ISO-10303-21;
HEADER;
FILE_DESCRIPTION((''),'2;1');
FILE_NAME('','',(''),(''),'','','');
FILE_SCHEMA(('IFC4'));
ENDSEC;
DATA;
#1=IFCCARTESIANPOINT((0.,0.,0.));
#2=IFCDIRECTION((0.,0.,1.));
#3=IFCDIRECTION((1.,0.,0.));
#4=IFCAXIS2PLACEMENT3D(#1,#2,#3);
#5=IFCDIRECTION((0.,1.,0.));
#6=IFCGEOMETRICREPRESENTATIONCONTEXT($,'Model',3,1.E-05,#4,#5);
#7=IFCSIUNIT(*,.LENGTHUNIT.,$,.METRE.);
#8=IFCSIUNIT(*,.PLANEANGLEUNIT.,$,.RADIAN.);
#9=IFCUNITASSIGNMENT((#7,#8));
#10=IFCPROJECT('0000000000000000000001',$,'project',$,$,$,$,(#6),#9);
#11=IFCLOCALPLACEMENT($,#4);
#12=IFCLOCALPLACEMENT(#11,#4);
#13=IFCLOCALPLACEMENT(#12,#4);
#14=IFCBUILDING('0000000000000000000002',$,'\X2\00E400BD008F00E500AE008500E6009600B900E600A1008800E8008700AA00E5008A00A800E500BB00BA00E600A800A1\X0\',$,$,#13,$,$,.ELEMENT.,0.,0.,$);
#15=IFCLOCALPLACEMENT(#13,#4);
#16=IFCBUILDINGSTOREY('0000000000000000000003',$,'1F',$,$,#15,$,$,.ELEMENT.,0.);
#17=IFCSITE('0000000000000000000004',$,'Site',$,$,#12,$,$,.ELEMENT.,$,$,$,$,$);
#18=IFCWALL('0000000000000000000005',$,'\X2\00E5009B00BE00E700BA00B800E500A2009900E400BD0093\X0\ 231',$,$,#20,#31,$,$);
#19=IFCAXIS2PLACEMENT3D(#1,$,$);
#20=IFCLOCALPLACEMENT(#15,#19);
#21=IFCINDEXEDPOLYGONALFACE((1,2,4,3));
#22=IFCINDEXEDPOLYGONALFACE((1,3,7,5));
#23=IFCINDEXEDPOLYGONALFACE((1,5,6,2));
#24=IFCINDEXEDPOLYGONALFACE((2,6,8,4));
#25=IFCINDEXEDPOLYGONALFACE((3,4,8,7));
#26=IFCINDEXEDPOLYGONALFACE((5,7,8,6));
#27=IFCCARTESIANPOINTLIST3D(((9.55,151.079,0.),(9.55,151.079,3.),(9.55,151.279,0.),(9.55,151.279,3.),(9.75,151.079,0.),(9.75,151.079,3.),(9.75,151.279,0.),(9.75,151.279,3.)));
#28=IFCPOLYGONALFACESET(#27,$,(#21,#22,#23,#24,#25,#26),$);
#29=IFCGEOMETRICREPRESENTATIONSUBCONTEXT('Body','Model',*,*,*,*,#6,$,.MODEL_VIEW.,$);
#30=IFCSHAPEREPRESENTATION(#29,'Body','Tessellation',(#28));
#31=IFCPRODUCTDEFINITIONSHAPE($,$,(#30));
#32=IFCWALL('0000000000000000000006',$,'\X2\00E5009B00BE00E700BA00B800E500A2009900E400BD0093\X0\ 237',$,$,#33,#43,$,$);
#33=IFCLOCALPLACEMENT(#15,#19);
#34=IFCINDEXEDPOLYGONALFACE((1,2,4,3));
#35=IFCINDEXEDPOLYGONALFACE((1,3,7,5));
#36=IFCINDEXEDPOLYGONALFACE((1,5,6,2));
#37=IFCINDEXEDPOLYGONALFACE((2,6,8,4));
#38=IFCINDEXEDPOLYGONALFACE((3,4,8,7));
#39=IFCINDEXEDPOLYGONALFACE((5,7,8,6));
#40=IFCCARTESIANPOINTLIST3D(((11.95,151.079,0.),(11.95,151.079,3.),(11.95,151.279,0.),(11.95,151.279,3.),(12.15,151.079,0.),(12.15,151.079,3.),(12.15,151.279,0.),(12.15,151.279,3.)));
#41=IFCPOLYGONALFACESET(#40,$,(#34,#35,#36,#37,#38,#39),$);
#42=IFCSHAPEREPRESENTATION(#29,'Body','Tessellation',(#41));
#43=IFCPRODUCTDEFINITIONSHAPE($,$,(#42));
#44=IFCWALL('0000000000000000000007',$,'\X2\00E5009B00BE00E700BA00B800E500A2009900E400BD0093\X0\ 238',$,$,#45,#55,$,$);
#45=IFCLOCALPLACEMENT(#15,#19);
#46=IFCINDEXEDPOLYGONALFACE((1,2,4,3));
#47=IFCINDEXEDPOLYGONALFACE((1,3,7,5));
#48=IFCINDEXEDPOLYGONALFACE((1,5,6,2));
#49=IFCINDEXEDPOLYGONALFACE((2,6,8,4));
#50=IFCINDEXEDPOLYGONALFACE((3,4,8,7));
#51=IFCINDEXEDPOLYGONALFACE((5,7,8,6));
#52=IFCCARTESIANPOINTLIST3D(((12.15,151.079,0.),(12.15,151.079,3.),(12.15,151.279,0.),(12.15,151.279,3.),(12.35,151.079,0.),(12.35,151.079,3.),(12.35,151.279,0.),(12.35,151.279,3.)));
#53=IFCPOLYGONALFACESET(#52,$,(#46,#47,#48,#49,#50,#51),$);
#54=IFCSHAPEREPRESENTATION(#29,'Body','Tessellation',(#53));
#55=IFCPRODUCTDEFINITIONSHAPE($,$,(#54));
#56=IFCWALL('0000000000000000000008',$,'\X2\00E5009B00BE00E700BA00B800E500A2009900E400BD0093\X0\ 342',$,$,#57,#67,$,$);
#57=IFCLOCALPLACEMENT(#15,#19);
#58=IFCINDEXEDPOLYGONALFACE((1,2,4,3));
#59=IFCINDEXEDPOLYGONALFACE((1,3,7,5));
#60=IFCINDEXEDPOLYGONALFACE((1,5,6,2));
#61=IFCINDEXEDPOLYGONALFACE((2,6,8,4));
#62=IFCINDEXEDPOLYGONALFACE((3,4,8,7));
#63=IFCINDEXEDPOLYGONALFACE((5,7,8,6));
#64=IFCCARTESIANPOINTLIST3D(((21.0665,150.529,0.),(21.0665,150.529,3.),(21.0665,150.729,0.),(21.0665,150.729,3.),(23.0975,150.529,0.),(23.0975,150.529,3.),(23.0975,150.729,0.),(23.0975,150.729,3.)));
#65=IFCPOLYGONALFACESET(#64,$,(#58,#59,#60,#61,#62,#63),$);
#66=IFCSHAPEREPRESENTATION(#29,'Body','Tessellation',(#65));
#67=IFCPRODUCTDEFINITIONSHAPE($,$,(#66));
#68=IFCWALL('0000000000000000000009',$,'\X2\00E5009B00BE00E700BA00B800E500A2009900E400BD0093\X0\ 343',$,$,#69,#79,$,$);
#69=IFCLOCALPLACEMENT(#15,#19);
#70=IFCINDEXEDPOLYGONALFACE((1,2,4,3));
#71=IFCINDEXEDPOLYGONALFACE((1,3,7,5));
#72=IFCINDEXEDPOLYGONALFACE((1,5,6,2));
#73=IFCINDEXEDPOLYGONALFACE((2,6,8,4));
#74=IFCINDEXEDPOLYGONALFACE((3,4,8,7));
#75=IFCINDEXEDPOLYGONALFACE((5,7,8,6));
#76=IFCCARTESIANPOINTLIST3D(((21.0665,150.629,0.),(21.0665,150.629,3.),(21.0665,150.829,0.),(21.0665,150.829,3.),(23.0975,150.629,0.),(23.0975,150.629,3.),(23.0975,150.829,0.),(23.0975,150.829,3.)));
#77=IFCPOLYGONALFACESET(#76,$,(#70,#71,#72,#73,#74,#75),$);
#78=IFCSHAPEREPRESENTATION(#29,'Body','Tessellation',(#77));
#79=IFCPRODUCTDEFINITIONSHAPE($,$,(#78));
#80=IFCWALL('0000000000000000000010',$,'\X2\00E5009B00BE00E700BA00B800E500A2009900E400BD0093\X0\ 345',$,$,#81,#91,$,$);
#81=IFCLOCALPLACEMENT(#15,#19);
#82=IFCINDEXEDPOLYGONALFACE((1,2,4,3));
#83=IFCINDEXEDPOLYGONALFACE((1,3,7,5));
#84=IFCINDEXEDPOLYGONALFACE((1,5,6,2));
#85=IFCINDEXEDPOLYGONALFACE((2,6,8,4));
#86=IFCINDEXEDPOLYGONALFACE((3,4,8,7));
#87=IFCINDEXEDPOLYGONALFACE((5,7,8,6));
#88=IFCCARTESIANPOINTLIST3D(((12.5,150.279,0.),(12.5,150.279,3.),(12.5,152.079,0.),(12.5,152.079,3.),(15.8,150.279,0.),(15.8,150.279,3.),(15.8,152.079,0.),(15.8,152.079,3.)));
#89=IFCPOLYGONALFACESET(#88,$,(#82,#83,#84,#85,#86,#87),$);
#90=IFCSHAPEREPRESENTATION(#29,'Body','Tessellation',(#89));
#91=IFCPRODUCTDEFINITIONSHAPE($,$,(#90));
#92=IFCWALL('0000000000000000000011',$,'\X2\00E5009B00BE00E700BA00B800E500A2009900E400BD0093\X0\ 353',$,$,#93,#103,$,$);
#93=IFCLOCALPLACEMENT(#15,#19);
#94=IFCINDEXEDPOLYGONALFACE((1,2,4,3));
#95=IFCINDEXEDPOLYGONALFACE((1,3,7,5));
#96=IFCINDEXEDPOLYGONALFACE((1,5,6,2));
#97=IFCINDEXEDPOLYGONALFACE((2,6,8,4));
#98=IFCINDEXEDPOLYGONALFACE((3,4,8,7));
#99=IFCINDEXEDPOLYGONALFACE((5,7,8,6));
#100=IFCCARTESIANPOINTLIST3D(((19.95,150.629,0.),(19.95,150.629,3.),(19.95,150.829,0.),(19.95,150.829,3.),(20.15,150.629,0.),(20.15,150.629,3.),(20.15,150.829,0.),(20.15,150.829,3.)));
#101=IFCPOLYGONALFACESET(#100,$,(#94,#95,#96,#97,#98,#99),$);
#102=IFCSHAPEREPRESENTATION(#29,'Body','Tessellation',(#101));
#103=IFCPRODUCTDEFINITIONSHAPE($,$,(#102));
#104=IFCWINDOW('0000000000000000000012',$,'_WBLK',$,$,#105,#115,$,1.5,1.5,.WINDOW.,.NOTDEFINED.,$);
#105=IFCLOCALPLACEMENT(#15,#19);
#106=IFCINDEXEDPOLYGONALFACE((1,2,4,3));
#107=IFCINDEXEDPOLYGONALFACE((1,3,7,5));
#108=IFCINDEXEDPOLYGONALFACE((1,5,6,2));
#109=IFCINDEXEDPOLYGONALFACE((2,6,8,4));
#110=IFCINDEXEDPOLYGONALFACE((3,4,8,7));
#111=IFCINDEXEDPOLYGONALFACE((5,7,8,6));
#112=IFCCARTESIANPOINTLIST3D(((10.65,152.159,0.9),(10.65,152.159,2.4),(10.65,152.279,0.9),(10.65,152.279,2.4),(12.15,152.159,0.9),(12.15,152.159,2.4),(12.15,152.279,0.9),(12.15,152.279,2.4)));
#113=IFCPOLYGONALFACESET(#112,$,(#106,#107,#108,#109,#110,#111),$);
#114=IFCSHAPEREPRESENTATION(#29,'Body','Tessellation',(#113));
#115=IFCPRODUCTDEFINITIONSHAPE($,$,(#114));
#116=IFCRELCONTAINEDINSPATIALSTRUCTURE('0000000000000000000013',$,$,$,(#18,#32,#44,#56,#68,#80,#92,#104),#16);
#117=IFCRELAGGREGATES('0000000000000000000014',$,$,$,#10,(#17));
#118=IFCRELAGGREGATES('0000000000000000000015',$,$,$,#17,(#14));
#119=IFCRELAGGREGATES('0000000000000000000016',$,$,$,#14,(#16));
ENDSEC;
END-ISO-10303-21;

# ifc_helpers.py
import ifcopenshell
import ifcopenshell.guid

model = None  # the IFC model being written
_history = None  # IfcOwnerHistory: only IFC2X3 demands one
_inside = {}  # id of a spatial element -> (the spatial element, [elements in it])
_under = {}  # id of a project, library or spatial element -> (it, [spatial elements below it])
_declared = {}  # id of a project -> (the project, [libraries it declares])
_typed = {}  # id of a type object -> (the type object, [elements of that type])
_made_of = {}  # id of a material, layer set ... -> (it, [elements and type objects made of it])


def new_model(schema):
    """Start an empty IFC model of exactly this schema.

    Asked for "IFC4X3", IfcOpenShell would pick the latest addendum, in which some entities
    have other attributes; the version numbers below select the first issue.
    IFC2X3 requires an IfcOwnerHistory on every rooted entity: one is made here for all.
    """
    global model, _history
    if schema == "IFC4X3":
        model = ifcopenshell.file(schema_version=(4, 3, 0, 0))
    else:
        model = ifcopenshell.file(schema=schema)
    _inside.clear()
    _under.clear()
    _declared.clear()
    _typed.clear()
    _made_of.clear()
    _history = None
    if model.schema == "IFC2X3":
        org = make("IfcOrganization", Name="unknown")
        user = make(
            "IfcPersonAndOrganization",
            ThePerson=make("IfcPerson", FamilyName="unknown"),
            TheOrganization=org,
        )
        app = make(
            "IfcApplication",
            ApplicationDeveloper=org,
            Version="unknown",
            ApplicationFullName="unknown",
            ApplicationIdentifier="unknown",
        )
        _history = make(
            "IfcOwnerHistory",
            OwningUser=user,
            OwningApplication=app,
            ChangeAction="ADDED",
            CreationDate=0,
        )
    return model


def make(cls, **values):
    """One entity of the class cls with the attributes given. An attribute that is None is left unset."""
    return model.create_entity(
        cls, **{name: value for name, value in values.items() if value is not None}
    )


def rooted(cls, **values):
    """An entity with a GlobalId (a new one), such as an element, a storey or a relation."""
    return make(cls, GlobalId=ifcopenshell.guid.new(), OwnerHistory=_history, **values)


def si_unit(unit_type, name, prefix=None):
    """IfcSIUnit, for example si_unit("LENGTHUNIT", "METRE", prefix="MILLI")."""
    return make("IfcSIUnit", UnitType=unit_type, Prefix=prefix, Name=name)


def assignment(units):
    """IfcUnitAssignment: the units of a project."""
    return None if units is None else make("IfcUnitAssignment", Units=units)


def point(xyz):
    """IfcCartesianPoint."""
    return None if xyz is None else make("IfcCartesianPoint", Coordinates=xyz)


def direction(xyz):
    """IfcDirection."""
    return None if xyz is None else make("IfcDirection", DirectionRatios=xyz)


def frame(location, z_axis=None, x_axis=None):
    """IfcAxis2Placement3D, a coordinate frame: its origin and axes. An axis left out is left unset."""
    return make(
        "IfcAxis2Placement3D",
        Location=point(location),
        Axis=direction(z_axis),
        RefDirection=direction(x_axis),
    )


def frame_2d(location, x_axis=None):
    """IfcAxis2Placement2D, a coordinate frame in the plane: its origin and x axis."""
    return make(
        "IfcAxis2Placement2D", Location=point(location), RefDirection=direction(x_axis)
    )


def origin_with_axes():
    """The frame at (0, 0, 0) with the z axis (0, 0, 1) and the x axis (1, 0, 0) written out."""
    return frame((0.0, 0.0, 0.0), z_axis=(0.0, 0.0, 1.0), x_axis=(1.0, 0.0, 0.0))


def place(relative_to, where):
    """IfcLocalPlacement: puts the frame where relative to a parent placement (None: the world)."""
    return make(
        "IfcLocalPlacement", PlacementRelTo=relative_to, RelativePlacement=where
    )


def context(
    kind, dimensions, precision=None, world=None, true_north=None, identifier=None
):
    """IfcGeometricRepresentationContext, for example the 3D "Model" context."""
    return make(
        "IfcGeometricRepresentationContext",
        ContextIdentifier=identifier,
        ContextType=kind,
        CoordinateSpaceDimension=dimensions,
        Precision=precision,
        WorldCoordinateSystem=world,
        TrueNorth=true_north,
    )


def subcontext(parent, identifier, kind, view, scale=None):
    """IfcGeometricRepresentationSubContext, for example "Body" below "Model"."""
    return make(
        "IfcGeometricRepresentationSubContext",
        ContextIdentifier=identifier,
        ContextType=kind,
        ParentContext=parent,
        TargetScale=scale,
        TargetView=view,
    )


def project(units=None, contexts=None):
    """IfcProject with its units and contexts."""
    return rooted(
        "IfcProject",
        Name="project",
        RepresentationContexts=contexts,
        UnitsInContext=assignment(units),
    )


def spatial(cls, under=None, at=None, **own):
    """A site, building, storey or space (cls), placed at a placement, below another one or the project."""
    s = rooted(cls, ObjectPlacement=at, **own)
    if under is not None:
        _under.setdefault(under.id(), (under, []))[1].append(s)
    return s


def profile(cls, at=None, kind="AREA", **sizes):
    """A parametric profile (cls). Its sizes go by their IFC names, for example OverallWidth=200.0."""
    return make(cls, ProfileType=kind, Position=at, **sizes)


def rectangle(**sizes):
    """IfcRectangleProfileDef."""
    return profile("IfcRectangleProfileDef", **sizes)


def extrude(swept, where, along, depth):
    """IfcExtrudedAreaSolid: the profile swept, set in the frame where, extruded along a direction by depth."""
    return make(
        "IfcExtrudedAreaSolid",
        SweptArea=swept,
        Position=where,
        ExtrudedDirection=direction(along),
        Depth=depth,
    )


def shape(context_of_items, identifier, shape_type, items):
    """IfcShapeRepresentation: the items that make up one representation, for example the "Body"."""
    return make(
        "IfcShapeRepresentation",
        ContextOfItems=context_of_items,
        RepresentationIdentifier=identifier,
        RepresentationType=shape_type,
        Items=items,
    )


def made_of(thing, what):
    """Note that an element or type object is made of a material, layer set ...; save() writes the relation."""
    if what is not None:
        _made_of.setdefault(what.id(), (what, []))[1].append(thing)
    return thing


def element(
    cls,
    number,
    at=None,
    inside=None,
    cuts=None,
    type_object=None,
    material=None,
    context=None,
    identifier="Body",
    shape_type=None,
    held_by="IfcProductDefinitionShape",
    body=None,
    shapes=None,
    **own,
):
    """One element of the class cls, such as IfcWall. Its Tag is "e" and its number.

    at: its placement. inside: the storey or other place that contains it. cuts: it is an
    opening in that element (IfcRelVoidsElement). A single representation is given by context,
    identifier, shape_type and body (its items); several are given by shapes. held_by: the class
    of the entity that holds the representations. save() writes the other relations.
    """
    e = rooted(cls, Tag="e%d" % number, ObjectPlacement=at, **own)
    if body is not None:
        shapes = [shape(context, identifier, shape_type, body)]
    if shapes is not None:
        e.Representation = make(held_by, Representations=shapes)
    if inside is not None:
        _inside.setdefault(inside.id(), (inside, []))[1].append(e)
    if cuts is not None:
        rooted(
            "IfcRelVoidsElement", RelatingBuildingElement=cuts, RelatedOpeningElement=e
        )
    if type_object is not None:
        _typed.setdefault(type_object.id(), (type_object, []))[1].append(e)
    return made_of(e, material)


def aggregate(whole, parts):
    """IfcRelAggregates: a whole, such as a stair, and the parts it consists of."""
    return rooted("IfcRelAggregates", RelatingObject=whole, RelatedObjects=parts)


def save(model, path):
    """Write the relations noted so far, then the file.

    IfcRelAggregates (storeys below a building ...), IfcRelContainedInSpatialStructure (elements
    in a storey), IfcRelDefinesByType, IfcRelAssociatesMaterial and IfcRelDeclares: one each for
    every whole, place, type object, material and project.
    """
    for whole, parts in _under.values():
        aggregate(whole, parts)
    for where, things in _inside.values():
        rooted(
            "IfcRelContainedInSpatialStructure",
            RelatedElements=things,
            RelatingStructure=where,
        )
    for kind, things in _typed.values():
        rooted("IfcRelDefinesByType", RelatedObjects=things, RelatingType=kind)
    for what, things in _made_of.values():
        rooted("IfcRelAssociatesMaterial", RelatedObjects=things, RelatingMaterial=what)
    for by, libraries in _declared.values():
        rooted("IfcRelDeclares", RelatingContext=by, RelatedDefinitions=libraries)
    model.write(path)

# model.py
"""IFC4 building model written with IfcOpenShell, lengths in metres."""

from ifc_helpers import new_model, si_unit, direction, frame, frame_2d, origin_with_axes, place, context, subcontext, project, spatial, rectangle, extrude, element, save


model = new_model("IFC4")

# Units and contexts
model_context = context("Model", 3, precision=1e-05, world=origin_with_axes(), true_north=direction((0.0, 1.0, 0.0)))
body_context = subcontext(model_context, "Body", "Model", "MODEL_VIEW")
ifc_project = project(units=[si_unit("LENGTHUNIT", "METRE"), si_unit("PLANEANGLEUNIT", "RADIAN")], contexts=[model_context])

# Site, building, storey
placement = place(None, origin_with_axes())
site_placement = place(placement, origin_with_axes())
site = spatial("IfcSite", under=ifc_project, at=site_placement, Name="Site", CompositionType="ELEMENT")
building_placement = place(site_placement, origin_with_axes())
building = spatial("IfcBuilding", under=site, at=building_placement, Name="ä½\u008få®\u0085æ\u0096¹æ¡\u0088è\u0087ªå\u008a¨å»ºæ¨¡", CompositionType="ELEMENT", ElevationOfRefHeight=0.0, ElevationOfTerrain=0.0)
storey_placement = place(building_placement, origin_with_axes())
storey = spatial("IfcBuildingStorey", under=building, at=storey_placement, Name="1F", CompositionType="ELEMENT", Elevation=0.0)

# Walls
for number, where, z_axis, x_axis, name in (
    (1, (9.65, 151.179, 0.0), (0.0, 0.0, 1.0), (1.0, 0.0, 0.0), "å\u009b¾çº¸å¢\u0099ä½\u0093 231"),
    (2, (12.05, 151.179, 0.0), (0.0, 0.0, 1.0), (1.0, 0.0, 0.0), "å\u009b¾çº¸å¢\u0099ä½\u0093 237"),
    (3, (12.25, 151.179, 0.0), (0.0, 0.0, 1.0), (-1.0, 0.0, 0.0), "å\u009b¾çº¸å¢\u0099ä½\u0093 238"),
):
    element("IfcWall", number, at=place(storey_placement, frame(where, z_axis=z_axis, x_axis=x_axis)), inside=storey, Name=name, context=body_context, shape_type="SweptSolid", body=[
        extrude(rectangle(XDim=0.2, YDim=0.2, at=frame_2d((0.0, 0.0), x_axis=(1.0, 0.0, 0.0))), frame((0.0, 0.0, 0.0), z_axis=(0.0, 0.0, 1.0)), (0.0, 0.0, 1.0), 3.0),
    ])
for number, where, z_axis, x_axis, name in (
    (4, (22.082, 150.629, 0.0), (0.0, 0.0, 1.0), (-1.0, 0.0, 0.0), "å\u009b¾çº¸å¢\u0099ä½\u0093 342"),
    (5, (22.082, 150.729, 0.0), (0.0, 0.0, 1.0), (-1.0, 0.0, 0.0), "å\u009b¾çº¸å¢\u0099ä½\u0093 343"),
):
    element("IfcWall", number, at=place(storey_placement, frame(where, z_axis=z_axis, x_axis=x_axis)), inside=storey, Name=name, context=body_context, shape_type="SweptSolid", body=[
        extrude(rectangle(XDim=2.031, YDim=0.2, at=frame_2d((0.0, 0.0), x_axis=(1.0, 0.0, 0.0))), frame((0.0, 0.0, 0.0), z_axis=(0.0, 0.0, 1.0)), (0.0, 0.0, 1.0), 3.0),
    ])
wall_1_placement = place(storey_placement, frame((14.15, 151.179, 0.0), z_axis=(0.0, 0.0, 1.0), x_axis=(1.0, 0.0, 0.0)))
element("IfcWall", 6, at=wall_1_placement, inside=storey, Name="å\u009b¾çº¸å¢\u0099ä½\u0093 345", context=body_context, shape_type="SweptSolid", body=[
    extrude(rectangle(XDim=3.3, YDim=1.8, at=frame_2d((0.0, 0.0), x_axis=(1.0, 0.0, 0.0))), frame((0.0, 0.0, 0.0), z_axis=(0.0, 0.0, 1.0)), (0.0, 0.0, 1.0), 3.0),
])
wall_2_placement = place(storey_placement, frame((20.05, 150.729, 0.0), z_axis=(0.0, 0.0, 1.0), x_axis=(-1.0, 0.0, 0.0)))
element("IfcWall", 7, at=wall_2_placement, inside=storey, Name="å\u009b¾çº¸å¢\u0099ä½\u0093 353", context=body_context, shape_type="SweptSolid", body=[
    extrude(rectangle(XDim=0.2, YDim=0.2, at=frame_2d((0.0, 0.0), x_axis=(1.0, 0.0, 0.0))), frame((0.0, 0.0, 0.0), z_axis=(0.0, 0.0, 1.0)), (0.0, 0.0, 1.0), 3.0),
])

# Window
window_placement = place(storey_placement, frame((11.4, 152.219, 0.9), z_axis=(0.0, 0.0, 1.0), x_axis=(1.0, 0.0, 0.0)))
element("IfcWindow", 8, at=window_placement, inside=storey, Name="_WBLK", OverallHeight=1.5, OverallWidth=1.5, PartitioningType="NOTDEFINED", PredefinedType="WINDOW", context=body_context, shape_type="SweptSolid", body=[
    extrude(rectangle(XDim=1.5, YDim=0.12, at=frame_2d((0.0, 0.0), x_axis=(1.0, 0.0, 0.0))), frame((0.0, 0.0, 0.0), z_axis=(0.0, 0.0, 1.0)), (0.0, 0.0, 1.0), 1.5),
])

save(model, "model.ifc")
